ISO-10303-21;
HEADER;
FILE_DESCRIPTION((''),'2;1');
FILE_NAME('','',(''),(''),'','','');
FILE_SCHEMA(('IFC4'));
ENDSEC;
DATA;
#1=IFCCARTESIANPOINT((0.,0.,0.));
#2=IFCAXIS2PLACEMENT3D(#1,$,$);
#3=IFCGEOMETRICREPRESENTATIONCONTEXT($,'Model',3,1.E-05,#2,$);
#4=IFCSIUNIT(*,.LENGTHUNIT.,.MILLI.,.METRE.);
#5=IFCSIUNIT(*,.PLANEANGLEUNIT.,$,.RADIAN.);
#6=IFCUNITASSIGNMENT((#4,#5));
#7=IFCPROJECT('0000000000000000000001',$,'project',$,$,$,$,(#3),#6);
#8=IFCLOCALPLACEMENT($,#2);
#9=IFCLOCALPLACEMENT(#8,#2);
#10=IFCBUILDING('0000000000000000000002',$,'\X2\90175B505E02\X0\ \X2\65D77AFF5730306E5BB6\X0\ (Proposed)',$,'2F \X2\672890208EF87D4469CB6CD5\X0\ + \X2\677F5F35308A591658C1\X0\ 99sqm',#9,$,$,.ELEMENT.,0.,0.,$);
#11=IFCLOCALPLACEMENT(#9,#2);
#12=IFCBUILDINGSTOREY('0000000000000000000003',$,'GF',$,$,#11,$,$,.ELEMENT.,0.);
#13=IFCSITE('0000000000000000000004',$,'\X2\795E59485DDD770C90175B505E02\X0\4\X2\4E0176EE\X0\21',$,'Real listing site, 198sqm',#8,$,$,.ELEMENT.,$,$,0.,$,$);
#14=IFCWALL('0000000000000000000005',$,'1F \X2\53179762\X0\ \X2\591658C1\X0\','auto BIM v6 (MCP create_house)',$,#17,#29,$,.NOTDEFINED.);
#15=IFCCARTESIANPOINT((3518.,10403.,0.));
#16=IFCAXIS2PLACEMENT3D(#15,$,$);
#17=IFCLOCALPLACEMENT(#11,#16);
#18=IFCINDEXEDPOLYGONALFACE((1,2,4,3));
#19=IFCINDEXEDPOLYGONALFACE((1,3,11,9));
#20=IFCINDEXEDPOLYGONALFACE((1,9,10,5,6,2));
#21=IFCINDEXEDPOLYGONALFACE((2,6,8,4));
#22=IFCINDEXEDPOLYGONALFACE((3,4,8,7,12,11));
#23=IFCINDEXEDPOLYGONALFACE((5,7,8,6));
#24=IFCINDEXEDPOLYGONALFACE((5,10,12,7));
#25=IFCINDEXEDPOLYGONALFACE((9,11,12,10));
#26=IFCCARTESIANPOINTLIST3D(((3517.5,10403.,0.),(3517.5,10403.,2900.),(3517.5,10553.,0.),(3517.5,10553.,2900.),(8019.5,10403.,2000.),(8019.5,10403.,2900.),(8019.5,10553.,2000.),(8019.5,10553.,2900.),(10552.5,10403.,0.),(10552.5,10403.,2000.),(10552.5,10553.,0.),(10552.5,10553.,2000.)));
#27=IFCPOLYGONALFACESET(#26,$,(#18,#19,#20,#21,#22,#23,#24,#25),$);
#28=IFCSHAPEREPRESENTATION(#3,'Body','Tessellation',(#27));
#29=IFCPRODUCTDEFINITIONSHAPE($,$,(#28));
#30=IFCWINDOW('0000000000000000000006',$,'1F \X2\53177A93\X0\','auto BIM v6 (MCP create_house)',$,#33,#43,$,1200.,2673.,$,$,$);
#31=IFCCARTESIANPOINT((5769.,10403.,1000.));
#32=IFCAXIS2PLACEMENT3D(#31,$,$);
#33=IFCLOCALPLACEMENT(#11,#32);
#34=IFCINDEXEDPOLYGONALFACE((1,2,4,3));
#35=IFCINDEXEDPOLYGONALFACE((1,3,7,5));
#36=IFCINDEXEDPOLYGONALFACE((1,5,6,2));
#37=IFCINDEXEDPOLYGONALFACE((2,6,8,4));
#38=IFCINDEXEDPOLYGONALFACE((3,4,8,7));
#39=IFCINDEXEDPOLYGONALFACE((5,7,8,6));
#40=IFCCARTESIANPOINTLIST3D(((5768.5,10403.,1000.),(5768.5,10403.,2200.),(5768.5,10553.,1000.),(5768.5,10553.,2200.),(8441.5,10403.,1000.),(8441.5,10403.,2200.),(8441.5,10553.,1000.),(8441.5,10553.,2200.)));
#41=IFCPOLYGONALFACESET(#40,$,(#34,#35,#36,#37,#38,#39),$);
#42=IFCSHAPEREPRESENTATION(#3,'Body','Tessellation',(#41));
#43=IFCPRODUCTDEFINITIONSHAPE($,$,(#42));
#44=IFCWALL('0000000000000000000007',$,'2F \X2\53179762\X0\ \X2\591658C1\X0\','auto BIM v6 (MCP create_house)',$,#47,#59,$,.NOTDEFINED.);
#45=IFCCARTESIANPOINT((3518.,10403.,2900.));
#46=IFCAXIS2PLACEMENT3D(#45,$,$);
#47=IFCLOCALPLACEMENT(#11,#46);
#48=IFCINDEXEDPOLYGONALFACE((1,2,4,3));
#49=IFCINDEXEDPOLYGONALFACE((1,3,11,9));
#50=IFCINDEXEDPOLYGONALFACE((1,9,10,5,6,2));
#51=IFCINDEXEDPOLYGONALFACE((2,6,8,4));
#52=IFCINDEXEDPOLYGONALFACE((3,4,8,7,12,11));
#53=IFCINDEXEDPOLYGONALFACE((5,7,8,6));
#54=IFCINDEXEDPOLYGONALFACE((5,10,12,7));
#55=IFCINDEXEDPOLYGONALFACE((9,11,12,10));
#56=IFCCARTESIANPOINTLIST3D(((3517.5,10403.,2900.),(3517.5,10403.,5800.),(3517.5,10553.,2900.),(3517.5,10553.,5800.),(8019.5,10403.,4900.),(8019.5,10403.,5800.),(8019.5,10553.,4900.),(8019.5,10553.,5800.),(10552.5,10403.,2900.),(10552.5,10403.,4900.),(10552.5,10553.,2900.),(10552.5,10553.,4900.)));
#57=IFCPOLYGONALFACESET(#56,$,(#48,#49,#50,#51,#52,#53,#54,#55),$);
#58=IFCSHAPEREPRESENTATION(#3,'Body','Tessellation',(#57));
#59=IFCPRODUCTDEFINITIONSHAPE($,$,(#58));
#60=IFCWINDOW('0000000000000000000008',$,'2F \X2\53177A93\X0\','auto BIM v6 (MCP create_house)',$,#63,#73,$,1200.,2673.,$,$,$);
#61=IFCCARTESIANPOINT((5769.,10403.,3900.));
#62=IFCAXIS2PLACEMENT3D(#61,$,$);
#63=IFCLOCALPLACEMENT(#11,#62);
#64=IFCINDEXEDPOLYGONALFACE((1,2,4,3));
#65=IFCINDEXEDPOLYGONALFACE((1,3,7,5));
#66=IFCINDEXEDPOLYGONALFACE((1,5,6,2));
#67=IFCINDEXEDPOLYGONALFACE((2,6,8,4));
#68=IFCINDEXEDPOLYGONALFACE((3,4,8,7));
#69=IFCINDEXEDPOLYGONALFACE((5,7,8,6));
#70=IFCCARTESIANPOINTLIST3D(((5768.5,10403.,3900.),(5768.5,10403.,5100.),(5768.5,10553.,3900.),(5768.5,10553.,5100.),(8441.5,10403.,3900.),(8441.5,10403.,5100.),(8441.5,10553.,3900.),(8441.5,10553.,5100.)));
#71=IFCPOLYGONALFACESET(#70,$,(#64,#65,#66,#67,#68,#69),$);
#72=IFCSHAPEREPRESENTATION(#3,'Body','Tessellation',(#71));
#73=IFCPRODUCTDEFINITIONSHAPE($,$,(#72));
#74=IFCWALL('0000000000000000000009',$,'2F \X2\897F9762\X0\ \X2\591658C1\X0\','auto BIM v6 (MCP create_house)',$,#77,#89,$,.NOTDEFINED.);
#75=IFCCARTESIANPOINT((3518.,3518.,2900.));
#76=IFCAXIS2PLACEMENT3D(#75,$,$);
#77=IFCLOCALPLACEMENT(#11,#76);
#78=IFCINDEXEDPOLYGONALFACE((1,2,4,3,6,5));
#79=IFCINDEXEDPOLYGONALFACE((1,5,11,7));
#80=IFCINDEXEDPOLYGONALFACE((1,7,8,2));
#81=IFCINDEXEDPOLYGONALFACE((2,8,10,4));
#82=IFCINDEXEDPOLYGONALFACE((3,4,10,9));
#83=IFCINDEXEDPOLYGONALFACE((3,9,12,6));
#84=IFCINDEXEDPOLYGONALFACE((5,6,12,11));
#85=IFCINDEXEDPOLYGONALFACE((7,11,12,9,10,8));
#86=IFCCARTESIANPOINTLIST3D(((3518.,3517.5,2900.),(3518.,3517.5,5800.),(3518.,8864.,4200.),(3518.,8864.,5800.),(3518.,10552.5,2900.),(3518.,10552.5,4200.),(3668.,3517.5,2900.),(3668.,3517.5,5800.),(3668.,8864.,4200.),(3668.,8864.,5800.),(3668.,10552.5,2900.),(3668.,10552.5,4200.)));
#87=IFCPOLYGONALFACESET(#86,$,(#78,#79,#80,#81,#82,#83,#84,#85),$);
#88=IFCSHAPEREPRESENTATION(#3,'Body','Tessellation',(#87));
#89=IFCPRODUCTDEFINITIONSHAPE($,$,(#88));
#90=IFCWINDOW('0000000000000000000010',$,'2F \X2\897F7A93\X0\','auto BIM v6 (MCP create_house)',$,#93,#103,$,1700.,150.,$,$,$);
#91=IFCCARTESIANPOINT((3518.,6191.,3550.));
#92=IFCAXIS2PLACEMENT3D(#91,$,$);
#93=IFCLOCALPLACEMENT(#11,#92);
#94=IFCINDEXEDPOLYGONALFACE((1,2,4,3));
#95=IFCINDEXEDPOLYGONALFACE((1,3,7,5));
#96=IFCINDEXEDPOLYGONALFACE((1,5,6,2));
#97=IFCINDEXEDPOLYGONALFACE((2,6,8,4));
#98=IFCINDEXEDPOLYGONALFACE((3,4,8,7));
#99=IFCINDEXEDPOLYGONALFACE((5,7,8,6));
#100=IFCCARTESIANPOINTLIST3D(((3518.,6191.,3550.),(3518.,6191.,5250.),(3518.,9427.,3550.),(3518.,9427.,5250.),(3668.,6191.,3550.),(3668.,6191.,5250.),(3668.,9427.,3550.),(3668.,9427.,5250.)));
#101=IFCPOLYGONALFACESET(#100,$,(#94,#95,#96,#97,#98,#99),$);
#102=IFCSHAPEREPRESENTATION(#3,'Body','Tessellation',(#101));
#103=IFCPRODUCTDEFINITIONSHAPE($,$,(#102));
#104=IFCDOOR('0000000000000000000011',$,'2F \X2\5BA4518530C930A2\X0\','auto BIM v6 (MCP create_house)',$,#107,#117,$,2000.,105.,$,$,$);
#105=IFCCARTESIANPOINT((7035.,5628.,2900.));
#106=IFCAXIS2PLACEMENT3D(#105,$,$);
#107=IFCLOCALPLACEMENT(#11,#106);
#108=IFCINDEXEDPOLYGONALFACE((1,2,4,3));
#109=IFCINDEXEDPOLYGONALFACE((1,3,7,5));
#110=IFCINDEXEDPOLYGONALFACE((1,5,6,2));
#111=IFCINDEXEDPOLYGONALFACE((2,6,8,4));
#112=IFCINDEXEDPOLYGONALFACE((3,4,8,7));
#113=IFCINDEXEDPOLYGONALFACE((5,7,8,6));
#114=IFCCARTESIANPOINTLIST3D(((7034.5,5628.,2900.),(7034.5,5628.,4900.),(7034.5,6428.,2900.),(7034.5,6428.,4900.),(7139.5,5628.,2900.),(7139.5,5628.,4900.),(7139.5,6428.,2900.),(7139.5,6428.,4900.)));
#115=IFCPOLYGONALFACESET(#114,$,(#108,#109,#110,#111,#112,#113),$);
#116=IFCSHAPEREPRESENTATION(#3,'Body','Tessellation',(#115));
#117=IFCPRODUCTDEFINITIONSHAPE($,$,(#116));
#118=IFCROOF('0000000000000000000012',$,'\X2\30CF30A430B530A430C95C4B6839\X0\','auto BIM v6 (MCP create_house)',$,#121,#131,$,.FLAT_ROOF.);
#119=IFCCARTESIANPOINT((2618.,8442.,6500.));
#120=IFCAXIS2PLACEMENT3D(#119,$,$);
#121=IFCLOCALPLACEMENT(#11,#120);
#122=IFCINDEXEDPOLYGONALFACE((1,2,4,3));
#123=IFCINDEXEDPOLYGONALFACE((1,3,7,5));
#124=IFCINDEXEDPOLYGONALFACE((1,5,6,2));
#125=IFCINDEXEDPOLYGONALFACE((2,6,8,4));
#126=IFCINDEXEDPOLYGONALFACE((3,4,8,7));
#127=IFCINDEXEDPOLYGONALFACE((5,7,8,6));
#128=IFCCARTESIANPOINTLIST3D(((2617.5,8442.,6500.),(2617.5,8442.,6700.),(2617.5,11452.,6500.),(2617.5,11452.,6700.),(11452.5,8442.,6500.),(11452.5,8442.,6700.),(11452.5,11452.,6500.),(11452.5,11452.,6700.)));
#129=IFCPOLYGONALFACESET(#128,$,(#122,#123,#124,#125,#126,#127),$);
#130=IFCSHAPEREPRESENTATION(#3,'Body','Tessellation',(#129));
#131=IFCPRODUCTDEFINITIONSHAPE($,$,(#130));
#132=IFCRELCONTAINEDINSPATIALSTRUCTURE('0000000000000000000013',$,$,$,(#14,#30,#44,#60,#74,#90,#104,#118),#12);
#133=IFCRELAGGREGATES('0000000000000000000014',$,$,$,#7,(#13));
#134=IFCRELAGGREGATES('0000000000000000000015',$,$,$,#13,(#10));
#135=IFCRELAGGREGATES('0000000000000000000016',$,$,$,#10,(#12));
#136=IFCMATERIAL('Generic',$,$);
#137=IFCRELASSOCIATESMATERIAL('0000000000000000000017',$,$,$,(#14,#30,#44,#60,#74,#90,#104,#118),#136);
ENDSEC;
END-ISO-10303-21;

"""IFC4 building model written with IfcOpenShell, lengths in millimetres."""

from ifc_helpers import new_model, si_unit, frame, frame_2d, origin, place, context, project, spatial, rectangle, extrude, material, element, fill, save


model = new_model("IFC4")

# Units and contexts
model_context = context("Model", 3, precision=1e-05, world=origin())
ifc_project = project(units=[si_unit("LENGTHUNIT", "METRE", prefix="MILLI"), si_unit("PLANEANGLEUNIT", "RADIAN")], contexts=[model_context])

# Site, building, storey
site_placement = place(None, origin())
site = spatial("IfcSite", under=ifc_project, at=site_placement, Name="神奈川県逗子市4丁目21", ObjectType="Real listing site, 198sqm", CompositionType="ELEMENT", RefElevation=0.0)
building_placement = place(site_placement, origin())
building = spatial("IfcBuilding", under=site, at=building_placement, Name="逗子市 旗竿地の家 (Proposed)", ObjectType="2F 木造軸組構法 + 板張り外壁 99sqm", CompositionType="ELEMENT", ElevationOfRefHeight=0.0, ElevationOfTerrain=0.0)
storey_placement = place(building_placement, origin())
storey = spatial("IfcBuildingStorey", under=building, at=storey_placement, Name="GF", CompositionType="ELEMENT", Elevation=0.0)

# Wall, opening, window
ifc_material = material(Name="Generic")
wall_1_placement = place(storey_placement, frame((3518.0, 10403.0, 0.0)))
wall_1 = element("IfcWall", 1, at=wall_1_placement, inside=storey, material=ifc_material, Name="1F 北面 外壁", Description="auto BIM v6 (MCP create_house)", PredefinedType="NOTDEFINED", context=model_context, shape_type="SweptSolid", body=[
    extrude(rectangle(XDim=7035.0, YDim=150.0, at=frame_2d((3517.0, 75.0))), frame((3518.0, 10403.0, 0.0)), (0.0, 0.0, 1.0), 2900.0),
])
opening_1_placement = place(storey_placement, frame((5769.0, 10403.0, 1000.0)))
opening_1 = element("IfcOpeningElement", 2, at=opening_1_placement, cuts=wall_1, PredefinedType="NOTDEFINED", context=model_context, shape_type="SweptSolid", body=[
    extrude(rectangle(XDim=2673.0, YDim=150.0, at=frame_2d((1336.0, 75.0))), frame((5769.0, 10403.0, 1000.0)), (0.0, 0.0, 1.0), 1200.0),
])
window_1_placement = place(storey_placement, frame((5769.0, 10403.0, 1000.0)))
window_1 = element("IfcWindow", 3, at=window_1_placement, inside=storey, material=ifc_material, Name="1F 北窓", Description="auto BIM v6 (MCP create_house)", OverallHeight=1200.0, OverallWidth=2673.0, context=model_context, shape_type="SweptSolid", body=[
    extrude(rectangle(XDim=2673.0, YDim=150.0, at=frame_2d((1336.0, 75.0))), frame((5769.0, 10403.0, 1000.0)), (0.0, 0.0, 1.0), 1200.0),
])
fill(opening_1, window_1)

# Walls, openings, windows
wall_2_placement = place(storey_placement, frame((3518.0, 10403.0, 2900.0)))
wall_2 = element("IfcWall", 4, at=wall_2_placement, inside=storey, material=ifc_material, Name="2F 北面 外壁", Description="auto BIM v6 (MCP create_house)", PredefinedType="NOTDEFINED", context=model_context, shape_type="SweptSolid", body=[
    extrude(rectangle(XDim=7035.0, YDim=150.0, at=frame_2d((3517.0, 75.0))), frame((3518.0, 10403.0, 2900.0)), (0.0, 0.0, 1.0), 2900.0),
])
opening_2_placement = place(storey_placement, frame((5769.0, 10403.0, 3900.0)))
opening_2 = element("IfcOpeningElement", 5, at=opening_2_placement, cuts=wall_2, PredefinedType="NOTDEFINED", context=model_context, shape_type="SweptSolid", body=[
    extrude(rectangle(XDim=2673.0, YDim=150.0, at=frame_2d((1336.0, 75.0))), frame((5769.0, 10403.0, 3900.0)), (0.0, 0.0, 1.0), 1200.0),
])
window_2_placement = place(storey_placement, frame((5769.0, 10403.0, 3900.0)))
window_2 = element("IfcWindow", 6, at=window_2_placement, inside=storey, material=ifc_material, Name="2F 北窓", Description="auto BIM v6 (MCP create_house)", OverallHeight=1200.0, OverallWidth=2673.0, context=model_context, shape_type="SweptSolid", body=[
    extrude(rectangle(XDim=2673.0, YDim=150.0, at=frame_2d((1336.0, 75.0))), frame((5769.0, 10403.0, 3900.0)), (0.0, 0.0, 1.0), 1200.0),
])
fill(opening_2, window_2)
wall_3_placement = place(storey_placement, frame((3518.0, 3518.0, 2900.0)))
wall_3 = element("IfcWall", 7, at=wall_3_placement, inside=storey, material=ifc_material, Name="2F 西面 外壁", Description="auto BIM v6 (MCP create_house)", PredefinedType="NOTDEFINED", context=model_context, shape_type="SweptSolid", body=[
    extrude(rectangle(XDim=150.0, YDim=7035.0, at=frame_2d((75.0, 3517.0))), frame((3518.0, 3518.0, 2900.0)), (0.0, 0.0, 1.0), 2900.0),
])
opening_3_placement = place(storey_placement, frame((3518.0, 6191.0, 3550.0)))
opening_3 = element("IfcOpeningElement", 8, at=opening_3_placement, cuts=wall_3, PredefinedType="NOTDEFINED", context=model_context, shape_type="SweptSolid", body=[
    extrude(rectangle(XDim=150.0, YDim=3236.0, at=frame_2d((75.0, 1618.0))), frame((3518.0, 6191.0, 3550.0)), (0.0, 0.0, 1.0), 1700.0),
])
window_3_placement = place(storey_placement, frame((3518.0, 6191.0, 3550.0)))
window_3 = element("IfcWindow", 9, at=window_3_placement, inside=storey, material=ifc_material, Name="2F 西窓", Description="auto BIM v6 (MCP create_house)", OverallHeight=1700.0, OverallWidth=150.0, context=model_context, shape_type="SweptSolid", body=[
    extrude(rectangle(XDim=150.0, YDim=3236.0, at=frame_2d((75.0, 1618.0))), frame((3518.0, 6191.0, 3550.0)), (0.0, 0.0, 1.0), 1700.0),
])
fill(opening_3, window_3)

# Door
door_placement = place(storey_placement, frame((7035.0, 5628.0, 2900.0)))
element("IfcDoor", 10, at=door_placement, inside=storey, material=ifc_material, Name="2F 室内ドア", Description="auto BIM v6 (MCP create_house)", OverallHeight=2000.0, OverallWidth=105.0, context=model_context, shape_type="SweptSolid", body=[
    extrude(rectangle(XDim=105.0, YDim=800.0, at=frame_2d((52.0, 400.0))), frame((7035.0, 5628.0, 2900.0)), (0.0, 0.0, 1.0), 2000.0),
])

# Roof
roof_placement = place(storey_placement, frame((2618.0, 8442.0, 6500.0)))
element("IfcRoof", 11, at=roof_placement, inside=storey, material=ifc_material, Name="ハイサイド屋根", Description="auto BIM v6 (MCP create_house)", PredefinedType="FLAT_ROOF", context=model_context, shape_type="SweptSolid", body=[
    extrude(rectangle(XDim=8835.0, YDim=3010.0, at=frame_2d((4417.0, 1505.0))), frame((2618.0, 8442.0, 6500.0)), (0.0, 0.0, 1.0), 200.0),
])

save(model, "model.ifc")
